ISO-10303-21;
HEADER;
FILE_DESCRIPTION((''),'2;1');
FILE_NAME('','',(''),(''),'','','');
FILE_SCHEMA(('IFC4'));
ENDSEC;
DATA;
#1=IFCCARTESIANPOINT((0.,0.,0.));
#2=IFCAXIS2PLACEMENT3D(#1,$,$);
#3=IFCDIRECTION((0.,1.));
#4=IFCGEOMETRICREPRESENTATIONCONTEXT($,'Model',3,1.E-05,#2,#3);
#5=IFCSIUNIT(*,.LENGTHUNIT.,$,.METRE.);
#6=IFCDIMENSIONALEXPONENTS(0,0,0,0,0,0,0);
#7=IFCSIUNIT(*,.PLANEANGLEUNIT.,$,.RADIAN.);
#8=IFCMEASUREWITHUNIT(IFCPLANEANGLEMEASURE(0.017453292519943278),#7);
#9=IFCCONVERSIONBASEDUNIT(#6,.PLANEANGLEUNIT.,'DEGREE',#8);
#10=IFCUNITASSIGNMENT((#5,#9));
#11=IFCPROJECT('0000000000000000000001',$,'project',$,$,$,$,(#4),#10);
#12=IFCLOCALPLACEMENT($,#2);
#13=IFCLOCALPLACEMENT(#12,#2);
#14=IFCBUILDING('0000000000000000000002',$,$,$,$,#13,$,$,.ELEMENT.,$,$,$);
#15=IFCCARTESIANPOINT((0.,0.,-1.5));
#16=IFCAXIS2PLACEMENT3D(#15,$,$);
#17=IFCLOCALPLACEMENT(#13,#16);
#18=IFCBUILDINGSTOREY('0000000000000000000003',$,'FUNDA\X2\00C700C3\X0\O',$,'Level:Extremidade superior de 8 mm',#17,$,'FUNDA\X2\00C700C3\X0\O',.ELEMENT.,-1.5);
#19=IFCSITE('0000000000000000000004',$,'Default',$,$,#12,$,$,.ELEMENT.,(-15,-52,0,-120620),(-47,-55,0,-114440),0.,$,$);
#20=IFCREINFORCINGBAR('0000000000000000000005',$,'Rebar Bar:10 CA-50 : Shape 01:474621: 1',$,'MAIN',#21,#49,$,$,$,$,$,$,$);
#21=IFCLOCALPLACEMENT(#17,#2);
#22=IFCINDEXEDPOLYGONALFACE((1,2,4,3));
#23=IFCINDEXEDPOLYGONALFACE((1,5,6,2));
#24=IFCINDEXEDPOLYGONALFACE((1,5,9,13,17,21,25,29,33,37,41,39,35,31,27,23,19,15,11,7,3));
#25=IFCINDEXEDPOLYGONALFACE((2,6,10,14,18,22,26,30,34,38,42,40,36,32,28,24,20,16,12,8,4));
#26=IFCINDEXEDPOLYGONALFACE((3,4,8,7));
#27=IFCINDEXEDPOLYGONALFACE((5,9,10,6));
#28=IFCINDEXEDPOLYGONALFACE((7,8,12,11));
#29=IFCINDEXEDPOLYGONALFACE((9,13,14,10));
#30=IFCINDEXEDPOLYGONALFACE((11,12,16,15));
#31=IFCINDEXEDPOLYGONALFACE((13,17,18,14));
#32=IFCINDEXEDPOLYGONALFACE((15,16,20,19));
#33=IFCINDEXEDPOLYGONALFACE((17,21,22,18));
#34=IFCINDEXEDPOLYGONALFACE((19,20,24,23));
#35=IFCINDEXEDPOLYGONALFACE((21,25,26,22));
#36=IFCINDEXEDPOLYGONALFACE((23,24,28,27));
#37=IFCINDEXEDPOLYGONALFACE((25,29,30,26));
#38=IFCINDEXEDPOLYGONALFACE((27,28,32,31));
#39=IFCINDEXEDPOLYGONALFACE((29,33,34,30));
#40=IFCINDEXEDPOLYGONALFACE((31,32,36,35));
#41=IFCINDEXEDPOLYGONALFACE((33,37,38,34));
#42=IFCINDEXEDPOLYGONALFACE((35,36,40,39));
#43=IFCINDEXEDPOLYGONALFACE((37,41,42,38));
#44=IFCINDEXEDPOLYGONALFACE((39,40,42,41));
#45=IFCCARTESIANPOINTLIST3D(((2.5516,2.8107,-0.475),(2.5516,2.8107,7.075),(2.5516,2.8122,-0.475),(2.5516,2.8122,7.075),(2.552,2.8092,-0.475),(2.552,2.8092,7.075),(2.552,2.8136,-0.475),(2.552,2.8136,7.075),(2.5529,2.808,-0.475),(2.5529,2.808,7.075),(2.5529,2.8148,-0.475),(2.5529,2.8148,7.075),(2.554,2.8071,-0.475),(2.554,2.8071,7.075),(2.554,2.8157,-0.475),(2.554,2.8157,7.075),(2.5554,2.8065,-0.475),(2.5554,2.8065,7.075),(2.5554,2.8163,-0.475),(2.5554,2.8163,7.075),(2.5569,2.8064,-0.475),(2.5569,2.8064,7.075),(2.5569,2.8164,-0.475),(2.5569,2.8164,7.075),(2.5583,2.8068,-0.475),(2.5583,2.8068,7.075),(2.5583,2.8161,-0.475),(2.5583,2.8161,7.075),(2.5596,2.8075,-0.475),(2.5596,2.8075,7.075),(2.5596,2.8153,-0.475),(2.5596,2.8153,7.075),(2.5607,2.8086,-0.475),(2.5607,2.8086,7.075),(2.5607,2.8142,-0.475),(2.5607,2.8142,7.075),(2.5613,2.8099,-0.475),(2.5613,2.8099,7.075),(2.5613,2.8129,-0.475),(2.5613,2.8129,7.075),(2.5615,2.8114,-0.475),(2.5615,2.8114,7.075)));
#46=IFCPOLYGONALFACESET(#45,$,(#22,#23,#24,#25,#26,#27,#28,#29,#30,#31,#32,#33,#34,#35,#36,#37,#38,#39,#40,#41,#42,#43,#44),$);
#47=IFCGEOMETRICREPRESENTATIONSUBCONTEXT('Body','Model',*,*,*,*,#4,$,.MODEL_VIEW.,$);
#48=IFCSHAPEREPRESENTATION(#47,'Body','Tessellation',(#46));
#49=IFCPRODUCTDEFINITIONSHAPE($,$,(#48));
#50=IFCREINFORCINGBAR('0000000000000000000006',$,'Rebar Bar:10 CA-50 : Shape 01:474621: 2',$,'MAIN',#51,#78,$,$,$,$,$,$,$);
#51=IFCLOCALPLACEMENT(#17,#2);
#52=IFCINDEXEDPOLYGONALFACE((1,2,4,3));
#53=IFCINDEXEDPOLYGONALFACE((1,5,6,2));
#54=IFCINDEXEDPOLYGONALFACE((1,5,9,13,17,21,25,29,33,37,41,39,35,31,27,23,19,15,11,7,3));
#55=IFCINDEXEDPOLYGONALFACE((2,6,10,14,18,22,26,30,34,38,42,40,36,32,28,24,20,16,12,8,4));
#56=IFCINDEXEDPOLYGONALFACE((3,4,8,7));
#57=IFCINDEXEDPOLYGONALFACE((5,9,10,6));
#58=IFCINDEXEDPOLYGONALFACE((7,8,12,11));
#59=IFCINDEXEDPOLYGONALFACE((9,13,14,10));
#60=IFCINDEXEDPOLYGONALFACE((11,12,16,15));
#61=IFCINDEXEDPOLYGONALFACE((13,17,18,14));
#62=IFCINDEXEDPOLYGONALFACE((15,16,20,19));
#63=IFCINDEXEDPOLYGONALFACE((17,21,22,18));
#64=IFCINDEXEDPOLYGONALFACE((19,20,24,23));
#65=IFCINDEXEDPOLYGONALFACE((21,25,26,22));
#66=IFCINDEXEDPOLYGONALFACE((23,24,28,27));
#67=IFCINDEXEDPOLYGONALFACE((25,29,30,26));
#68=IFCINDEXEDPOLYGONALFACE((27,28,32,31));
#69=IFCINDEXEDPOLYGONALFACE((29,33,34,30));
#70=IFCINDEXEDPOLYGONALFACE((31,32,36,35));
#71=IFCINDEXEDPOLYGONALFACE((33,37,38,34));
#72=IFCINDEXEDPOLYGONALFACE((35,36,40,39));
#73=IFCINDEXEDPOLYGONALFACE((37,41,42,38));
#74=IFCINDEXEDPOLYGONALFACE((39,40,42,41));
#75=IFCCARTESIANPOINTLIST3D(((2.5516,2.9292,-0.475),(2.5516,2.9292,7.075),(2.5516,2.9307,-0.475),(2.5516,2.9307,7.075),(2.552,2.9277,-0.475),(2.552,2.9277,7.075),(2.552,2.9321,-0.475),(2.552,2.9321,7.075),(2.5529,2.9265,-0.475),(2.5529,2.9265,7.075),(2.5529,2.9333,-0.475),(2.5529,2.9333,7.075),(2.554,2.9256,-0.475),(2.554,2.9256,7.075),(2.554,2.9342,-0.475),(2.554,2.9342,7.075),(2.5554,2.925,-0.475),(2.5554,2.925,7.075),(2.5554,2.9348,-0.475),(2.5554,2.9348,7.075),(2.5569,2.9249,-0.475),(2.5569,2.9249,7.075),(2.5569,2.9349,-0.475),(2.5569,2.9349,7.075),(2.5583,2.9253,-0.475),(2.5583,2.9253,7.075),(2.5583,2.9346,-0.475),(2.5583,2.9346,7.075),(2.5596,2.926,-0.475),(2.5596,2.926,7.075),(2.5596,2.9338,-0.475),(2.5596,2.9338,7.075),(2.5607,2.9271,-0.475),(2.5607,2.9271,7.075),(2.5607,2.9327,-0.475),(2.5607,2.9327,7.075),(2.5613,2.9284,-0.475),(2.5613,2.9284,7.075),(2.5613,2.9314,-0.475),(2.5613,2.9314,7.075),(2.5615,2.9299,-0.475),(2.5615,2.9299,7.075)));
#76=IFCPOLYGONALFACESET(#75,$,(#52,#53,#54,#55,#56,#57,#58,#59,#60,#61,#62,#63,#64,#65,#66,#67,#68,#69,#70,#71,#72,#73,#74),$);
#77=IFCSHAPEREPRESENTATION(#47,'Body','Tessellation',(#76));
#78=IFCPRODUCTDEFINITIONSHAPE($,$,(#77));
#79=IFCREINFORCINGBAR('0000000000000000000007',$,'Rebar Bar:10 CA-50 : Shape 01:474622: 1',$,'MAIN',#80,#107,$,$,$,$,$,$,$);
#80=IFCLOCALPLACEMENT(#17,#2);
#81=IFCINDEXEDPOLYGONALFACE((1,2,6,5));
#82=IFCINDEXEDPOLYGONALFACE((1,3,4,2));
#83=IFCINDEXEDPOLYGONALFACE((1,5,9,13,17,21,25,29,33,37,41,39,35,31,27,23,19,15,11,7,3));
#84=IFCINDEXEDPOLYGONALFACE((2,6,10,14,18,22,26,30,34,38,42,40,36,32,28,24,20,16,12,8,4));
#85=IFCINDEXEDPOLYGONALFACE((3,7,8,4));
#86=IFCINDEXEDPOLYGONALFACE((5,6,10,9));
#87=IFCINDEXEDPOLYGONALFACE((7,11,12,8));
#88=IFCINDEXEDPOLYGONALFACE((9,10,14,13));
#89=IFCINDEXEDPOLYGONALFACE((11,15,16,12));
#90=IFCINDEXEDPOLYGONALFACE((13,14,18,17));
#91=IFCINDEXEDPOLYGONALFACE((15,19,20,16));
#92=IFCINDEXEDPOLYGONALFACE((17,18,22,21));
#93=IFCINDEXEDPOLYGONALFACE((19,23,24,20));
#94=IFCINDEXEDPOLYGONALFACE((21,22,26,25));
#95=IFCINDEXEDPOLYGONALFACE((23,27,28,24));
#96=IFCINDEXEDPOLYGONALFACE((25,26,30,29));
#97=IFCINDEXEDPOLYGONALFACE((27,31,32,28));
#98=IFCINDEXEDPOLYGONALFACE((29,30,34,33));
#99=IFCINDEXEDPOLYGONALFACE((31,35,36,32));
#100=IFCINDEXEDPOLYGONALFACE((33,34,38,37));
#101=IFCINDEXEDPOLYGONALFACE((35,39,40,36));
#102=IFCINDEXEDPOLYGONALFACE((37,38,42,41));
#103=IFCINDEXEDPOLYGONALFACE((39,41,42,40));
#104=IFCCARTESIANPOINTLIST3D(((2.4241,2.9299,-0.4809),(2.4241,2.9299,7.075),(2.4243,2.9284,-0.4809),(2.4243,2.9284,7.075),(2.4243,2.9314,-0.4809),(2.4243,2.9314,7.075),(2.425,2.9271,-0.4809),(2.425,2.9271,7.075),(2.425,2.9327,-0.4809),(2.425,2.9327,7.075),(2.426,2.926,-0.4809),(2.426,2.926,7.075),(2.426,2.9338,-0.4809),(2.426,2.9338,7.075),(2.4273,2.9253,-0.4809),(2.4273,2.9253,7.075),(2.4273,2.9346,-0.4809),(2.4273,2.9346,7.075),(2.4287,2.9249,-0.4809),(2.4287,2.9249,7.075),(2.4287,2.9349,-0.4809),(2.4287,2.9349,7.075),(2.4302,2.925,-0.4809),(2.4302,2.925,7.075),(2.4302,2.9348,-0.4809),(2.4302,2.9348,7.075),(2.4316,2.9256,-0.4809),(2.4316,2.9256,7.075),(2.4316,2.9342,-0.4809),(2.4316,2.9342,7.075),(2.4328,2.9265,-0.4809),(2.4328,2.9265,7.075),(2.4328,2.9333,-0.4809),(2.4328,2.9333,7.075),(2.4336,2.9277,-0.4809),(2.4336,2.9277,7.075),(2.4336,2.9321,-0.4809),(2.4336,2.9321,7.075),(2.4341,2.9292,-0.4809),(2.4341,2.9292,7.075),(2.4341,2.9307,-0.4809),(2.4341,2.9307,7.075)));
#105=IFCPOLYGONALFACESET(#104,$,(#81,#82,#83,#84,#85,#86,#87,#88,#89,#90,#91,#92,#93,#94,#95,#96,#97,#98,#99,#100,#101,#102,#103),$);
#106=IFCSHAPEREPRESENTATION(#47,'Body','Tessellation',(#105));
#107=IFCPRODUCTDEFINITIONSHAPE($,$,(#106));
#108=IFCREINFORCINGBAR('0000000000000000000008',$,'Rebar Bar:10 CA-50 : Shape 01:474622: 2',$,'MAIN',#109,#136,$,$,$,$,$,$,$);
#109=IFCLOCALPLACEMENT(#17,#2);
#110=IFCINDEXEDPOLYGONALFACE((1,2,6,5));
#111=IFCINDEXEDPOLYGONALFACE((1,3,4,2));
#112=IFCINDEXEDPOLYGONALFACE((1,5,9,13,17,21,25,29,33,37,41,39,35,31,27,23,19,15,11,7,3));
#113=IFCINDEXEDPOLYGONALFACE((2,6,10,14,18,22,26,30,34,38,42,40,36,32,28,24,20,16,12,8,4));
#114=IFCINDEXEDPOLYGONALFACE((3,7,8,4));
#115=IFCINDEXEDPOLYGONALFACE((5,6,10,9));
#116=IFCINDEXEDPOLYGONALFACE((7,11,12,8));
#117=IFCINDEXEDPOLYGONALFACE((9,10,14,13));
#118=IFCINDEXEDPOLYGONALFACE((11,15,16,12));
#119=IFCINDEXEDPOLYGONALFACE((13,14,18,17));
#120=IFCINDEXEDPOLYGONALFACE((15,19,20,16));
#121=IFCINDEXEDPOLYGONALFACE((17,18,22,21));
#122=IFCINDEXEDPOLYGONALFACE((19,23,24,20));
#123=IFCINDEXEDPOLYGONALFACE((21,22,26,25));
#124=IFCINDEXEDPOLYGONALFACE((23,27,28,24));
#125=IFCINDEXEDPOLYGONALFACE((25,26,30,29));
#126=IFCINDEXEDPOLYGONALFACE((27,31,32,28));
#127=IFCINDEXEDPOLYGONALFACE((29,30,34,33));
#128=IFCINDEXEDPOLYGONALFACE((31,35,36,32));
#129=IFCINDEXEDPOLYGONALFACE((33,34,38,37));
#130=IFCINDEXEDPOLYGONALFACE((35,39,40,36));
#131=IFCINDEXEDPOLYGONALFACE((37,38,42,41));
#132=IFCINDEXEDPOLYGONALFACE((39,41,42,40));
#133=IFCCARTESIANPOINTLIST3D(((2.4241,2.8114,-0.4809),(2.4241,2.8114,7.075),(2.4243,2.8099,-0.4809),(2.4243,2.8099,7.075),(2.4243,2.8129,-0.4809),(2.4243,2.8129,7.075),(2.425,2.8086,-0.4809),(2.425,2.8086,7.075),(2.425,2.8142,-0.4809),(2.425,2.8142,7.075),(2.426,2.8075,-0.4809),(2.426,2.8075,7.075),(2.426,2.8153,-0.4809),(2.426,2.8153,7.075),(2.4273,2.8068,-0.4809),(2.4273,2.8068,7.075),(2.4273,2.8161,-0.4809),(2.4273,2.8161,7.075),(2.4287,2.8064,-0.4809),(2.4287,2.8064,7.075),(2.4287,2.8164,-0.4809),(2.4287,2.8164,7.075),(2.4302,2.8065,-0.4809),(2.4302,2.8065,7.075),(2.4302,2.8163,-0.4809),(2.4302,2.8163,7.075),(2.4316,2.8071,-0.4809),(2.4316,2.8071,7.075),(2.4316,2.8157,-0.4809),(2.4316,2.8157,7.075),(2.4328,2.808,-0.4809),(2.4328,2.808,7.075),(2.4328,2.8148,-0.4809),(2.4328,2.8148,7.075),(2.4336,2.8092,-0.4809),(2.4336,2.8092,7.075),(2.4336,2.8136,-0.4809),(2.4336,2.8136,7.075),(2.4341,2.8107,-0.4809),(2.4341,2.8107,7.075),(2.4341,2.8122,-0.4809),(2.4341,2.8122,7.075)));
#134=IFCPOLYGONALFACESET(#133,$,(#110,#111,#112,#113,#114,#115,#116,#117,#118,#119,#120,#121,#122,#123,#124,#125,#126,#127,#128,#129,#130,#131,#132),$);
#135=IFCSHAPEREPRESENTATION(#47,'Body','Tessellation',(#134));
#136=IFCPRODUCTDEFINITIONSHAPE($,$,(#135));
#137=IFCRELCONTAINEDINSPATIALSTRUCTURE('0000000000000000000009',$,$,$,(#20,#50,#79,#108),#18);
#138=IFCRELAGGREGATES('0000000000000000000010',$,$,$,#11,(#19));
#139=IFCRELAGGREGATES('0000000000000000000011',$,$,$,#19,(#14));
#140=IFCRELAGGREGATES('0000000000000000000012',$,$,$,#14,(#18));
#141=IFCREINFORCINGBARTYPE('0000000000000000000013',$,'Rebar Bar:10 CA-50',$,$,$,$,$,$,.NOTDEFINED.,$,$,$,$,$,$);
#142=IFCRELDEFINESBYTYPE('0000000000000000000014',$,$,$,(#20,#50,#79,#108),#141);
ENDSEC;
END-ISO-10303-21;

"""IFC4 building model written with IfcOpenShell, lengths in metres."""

from ifc_helpers import new_model, entity, si_unit, converted_unit, direction, frame, origin, place, context, subcontext, project, spatial, type_object, element, save


model = new_model("IFC4")

# Units and contexts
model_context = context("Model", 3, precision=1e-05, world=origin(), true_north=direction((0.0, 1.0)))
body_context = subcontext(model_context, "Body", "Model", "MODEL_VIEW")
ifc_project = project(units=[si_unit("LENGTHUNIT", "METRE"), converted_unit("PLANEANGLEUNIT", "DEGREE", entity("IfcPlaneAngleMeasure", 0.017453292519943278), si_unit("PLANEANGLEUNIT", "RADIAN"), dimensions=[0, 0, 0, 0, 0, 0, 0])], contexts=[model_context])

# Site, building, storey
site_placement = place(None, origin())
site = spatial("IfcSite", under=ifc_project, at=site_placement, Name="Default", CompositionType="ELEMENT", RefLatitude=(-15, -52, 0, -120620), RefLongitude=(-47, -55, 0, -114440), RefElevation=0.0)
building_placement = place(site_placement, origin())
building = spatial("IfcBuilding", under=site, at=building_placement, CompositionType="ELEMENT")
storey_placement = place(building_placement, frame((0.0, 0.0, -1.5)))
storey = spatial("IfcBuildingStorey", under=building, at=storey_placement, Name="FUNDAÇÃO", ObjectType="Level:Extremidade superior de 8 mm", LongName="FUNDAÇÃO", CompositionType="ELEMENT", Elevation=-1.5)

# Reinforcing bars
reinforcing_bar_type_1 = type_object("IfcReinforcingBarType", Name="Rebar Bar:10 CA-50", PredefinedType="NOTDEFINED")
reinforcing_bar_1_placement = place(storey_placement, origin())
element("IfcReinforcingBar", 1, at=reinforcing_bar_1_placement, inside=storey, type_object=reinforcing_bar_type_1, Name="Rebar Bar:10 CA-50 : Shape 01:474621: 1", ObjectType="MAIN", context=body_context, shape_type="AdvancedSweptSolid", body=[
    entity("IfcSweptDiskSolid", entity("IfcIndexedPolyCurve", entity("IfcCartesianPointList3D", [[2.5565, 2.8114, -0.475], [2.5565, 2.8114, 7.075]]), None, False), 0.005, None, 0.0, 1.0),
])
reinforcing_bar_2_placement = place(storey_placement, origin())
element("IfcReinforcingBar", 2, at=reinforcing_bar_2_placement, inside=storey, type_object=reinforcing_bar_type_1, Name="Rebar Bar:10 CA-50 : Shape 01:474621: 2", ObjectType="MAIN", context=body_context, shape_type="AdvancedSweptSolid", body=[
    entity("IfcSweptDiskSolid", entity("IfcIndexedPolyCurve", entity("IfcCartesianPointList3D", [[2.5565, 2.9299, -0.475], [2.5565, 2.9299, 7.075]]), None, False), 0.005, None, 0.0, 1.0),
])
reinforcing_bar_3_placement = place(storey_placement, origin())
element("IfcReinforcingBar", 3, at=reinforcing_bar_3_placement, inside=storey, type_object=reinforcing_bar_type_1, Name="Rebar Bar:10 CA-50 : Shape 01:474622: 1", ObjectType="MAIN", context=body_context, shape_type="AdvancedSweptSolid", body=[
    entity("IfcSweptDiskSolid", entity("IfcIndexedPolyCurve", entity("IfcCartesianPointList3D", [[2.4291, 2.9299, 7.075], [2.4291, 2.9299, -0.4809]]), None, False), 0.005, None, 0.0, 1.0),
])
reinforcing_bar_4_placement = place(storey_placement, origin())
element("IfcReinforcingBar", 4, at=reinforcing_bar_4_placement, inside=storey, type_object=reinforcing_bar_type_1, Name="Rebar Bar:10 CA-50 : Shape 01:474622: 2", ObjectType="MAIN", context=body_context, shape_type="AdvancedSweptSolid", body=[
    entity("IfcSweptDiskSolid", entity("IfcIndexedPolyCurve", entity("IfcCartesianPointList3D", [[2.4291, 2.8114, 7.075], [2.4291, 2.8114, -0.4809]]), None, False), 0.005, None, 0.0, 1.0),
])

save(model, "model.ifc")
